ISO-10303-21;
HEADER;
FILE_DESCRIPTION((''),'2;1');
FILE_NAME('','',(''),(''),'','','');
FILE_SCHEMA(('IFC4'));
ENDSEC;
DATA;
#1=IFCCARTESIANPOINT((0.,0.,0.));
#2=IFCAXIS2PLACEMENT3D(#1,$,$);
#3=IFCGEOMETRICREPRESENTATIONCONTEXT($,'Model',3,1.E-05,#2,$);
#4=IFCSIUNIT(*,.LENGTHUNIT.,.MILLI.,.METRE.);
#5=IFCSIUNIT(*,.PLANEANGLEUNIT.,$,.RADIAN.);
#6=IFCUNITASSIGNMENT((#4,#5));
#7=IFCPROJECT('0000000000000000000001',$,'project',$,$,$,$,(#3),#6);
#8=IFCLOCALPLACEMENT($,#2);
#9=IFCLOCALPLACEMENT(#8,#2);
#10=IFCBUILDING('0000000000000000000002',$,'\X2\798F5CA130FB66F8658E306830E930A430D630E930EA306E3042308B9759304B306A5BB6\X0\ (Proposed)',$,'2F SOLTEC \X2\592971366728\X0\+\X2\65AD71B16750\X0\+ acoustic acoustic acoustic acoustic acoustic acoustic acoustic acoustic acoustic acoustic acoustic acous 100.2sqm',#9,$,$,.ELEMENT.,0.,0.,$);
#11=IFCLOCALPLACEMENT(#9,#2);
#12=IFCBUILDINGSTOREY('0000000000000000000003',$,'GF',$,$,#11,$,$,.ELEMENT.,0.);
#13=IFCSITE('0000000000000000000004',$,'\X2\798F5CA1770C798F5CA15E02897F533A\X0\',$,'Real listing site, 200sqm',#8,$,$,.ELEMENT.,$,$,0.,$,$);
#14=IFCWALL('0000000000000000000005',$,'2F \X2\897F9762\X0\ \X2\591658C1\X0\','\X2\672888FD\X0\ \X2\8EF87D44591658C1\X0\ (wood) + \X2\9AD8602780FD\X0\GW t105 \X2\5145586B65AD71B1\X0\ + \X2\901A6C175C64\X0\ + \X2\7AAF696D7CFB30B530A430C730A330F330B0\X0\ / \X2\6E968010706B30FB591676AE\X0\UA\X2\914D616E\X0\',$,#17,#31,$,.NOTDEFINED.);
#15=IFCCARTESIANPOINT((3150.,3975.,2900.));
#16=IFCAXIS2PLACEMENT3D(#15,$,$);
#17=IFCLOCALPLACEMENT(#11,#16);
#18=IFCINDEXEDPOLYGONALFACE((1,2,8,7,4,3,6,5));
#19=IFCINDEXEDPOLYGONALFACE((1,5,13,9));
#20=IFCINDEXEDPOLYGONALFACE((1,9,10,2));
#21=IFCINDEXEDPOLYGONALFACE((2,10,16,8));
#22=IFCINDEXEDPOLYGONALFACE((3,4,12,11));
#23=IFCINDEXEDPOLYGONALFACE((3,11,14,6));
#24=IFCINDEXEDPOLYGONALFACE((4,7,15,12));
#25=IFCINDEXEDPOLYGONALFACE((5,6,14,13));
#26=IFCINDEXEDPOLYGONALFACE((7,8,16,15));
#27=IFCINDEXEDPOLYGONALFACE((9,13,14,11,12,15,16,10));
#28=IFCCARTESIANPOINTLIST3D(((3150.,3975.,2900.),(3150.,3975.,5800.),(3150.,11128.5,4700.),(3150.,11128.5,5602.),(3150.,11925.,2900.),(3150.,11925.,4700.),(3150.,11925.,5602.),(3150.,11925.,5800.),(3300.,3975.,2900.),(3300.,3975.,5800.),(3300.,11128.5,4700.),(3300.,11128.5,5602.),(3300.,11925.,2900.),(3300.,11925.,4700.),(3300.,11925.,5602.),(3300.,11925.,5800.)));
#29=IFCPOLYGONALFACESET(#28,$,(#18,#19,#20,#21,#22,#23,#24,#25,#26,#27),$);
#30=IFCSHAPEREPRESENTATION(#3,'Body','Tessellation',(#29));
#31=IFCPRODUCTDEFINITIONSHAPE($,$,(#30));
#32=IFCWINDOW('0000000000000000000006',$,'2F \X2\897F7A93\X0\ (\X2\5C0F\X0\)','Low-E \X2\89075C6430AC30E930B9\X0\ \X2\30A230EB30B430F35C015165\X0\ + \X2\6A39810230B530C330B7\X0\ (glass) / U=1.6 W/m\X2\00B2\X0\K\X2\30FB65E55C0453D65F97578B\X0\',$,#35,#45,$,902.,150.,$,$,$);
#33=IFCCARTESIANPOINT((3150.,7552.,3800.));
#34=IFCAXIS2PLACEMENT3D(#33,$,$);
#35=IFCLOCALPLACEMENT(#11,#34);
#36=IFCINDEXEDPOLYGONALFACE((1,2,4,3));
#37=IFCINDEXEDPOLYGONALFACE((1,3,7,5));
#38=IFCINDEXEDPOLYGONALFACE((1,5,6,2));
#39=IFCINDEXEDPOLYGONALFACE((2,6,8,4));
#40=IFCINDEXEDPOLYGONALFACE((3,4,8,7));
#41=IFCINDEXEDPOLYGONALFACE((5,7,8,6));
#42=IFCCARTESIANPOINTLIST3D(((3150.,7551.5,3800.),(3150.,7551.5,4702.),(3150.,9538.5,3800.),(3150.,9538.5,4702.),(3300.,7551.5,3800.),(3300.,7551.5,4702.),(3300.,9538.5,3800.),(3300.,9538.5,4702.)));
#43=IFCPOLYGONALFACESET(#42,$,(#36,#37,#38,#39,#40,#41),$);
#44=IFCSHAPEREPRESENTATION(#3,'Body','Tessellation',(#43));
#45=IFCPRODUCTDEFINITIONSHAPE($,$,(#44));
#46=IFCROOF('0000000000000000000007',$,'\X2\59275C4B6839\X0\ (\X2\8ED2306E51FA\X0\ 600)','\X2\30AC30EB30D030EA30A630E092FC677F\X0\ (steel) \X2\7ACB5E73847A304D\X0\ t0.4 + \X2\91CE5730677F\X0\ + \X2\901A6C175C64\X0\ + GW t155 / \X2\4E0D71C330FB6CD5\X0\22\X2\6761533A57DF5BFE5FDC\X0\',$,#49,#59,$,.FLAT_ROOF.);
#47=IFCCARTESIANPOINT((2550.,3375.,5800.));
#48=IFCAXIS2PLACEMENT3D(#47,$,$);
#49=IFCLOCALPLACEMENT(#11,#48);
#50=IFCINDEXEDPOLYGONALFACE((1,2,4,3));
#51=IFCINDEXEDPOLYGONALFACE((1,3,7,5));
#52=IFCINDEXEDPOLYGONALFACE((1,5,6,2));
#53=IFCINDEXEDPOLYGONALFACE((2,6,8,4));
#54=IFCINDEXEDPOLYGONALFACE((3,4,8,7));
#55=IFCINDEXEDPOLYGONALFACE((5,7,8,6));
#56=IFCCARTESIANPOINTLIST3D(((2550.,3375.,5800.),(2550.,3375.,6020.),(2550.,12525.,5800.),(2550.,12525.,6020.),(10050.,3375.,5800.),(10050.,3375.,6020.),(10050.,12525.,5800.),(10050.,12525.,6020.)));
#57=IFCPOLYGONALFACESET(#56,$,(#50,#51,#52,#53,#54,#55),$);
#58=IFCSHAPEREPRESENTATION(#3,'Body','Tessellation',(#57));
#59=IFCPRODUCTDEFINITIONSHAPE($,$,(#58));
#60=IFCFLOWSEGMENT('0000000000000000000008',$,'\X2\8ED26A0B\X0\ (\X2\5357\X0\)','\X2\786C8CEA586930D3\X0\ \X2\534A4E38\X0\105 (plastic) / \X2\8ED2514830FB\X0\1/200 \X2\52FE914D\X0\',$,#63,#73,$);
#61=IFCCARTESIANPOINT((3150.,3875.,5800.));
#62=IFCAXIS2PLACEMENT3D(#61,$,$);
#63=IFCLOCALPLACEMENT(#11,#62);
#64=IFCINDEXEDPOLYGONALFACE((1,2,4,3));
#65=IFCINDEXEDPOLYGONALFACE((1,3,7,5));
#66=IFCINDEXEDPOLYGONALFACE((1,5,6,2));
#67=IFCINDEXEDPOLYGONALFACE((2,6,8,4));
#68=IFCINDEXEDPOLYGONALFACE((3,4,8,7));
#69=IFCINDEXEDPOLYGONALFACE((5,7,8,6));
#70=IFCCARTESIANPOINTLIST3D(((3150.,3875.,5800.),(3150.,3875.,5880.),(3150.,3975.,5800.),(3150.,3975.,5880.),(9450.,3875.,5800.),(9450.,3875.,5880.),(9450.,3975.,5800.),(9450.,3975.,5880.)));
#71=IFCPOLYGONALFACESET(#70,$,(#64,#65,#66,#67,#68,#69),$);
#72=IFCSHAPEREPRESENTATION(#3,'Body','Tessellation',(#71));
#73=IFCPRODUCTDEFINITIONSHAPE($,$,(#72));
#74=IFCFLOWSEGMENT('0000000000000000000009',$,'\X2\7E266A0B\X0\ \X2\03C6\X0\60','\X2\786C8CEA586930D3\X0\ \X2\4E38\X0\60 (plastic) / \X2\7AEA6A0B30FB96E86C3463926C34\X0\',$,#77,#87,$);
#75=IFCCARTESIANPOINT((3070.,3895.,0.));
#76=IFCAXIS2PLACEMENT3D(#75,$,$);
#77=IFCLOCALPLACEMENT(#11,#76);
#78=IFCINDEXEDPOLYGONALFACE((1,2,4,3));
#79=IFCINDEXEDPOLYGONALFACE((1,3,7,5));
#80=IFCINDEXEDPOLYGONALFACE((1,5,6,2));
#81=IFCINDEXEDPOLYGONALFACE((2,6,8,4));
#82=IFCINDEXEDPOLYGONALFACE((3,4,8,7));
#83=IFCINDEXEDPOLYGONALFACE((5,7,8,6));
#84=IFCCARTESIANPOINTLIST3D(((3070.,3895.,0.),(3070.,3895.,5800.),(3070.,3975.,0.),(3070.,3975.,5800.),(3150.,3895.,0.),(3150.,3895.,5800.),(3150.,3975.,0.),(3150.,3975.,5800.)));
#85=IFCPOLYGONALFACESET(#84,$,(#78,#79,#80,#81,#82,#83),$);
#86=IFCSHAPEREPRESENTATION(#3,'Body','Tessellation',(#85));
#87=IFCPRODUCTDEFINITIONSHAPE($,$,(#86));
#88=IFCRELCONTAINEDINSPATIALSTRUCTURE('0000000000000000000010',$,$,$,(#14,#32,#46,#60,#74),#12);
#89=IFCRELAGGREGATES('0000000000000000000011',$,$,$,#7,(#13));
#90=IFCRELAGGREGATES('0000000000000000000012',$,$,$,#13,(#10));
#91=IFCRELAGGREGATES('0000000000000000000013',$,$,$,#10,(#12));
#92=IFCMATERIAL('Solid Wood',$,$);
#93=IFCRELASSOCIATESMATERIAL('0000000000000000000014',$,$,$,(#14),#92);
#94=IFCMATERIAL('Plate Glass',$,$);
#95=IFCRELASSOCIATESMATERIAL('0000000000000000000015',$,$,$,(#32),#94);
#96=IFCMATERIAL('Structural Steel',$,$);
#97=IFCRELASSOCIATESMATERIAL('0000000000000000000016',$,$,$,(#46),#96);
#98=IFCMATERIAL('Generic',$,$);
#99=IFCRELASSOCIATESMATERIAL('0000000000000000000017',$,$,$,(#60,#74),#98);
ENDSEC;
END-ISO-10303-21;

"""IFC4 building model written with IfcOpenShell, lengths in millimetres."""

from ifc_helpers import new_model, si_unit, frame, frame_2d, origin, place, context, project, spatial, rectangle, extrude, material, element, fill, save


model = new_model("IFC4")

# Units and contexts
model_context = context("Model", 3, precision=1e-05, world=origin())
ifc_project = project(units=[si_unit("LENGTHUNIT", "METRE", prefix="MILLI"), si_unit("PLANEANGLEUNIT", "RADIAN")], contexts=[model_context])

# Site, building, storey
site_placement = place(None, origin())
site = spatial("IfcSite", under=ifc_project, at=site_placement, Name="福岡県福岡市西区", ObjectType="Real listing site, 200sqm", CompositionType="ELEMENT", RefElevation=0.0)
building_placement = place(site_placement, origin())
building = spatial("IfcBuilding", under=site, at=building_placement, Name="福岡・書斎とライブラリのある静かな家 (Proposed)", ObjectType="2F SOLTEC 天然木+断熱材+ acoustic acoustic acoustic acoustic acoustic acoustic acoustic acoustic acoustic acoustic acoustic acous 100.2sqm", CompositionType="ELEMENT", ElevationOfRefHeight=0.0, ElevationOfTerrain=0.0)
storey_placement = place(building_placement, origin())
storey = spatial("IfcBuildingStorey", under=building, at=storey_placement, Name="GF", CompositionType="ELEMENT", Elevation=0.0)

# Shared definitions
ifc_material_1 = material(Name="Solid Wood")

# Shared definitions
ifc_material_2 = material(Name="Plate Glass")

# Wall, opening, window
wall_1_placement = place(storey_placement, frame((3150.0, 3975.0, 2900.0)))
wall_1 = element("IfcWall", 1, at=wall_1_placement, inside=storey, material=ifc_material_1, Name="2F 西面 外壁", Description="木製 軸組外壁 (wood) + 高性能GW t105 充填断熱 + 通気層 + 窯業系サイディング / 準耐火・外皮UA配慮", PredefinedType="NOTDEFINED", context=model_context, shape_type="SweptSolid", body=[
    extrude(rectangle(XDim=150.0, YDim=7950.0, at=frame_2d((75.0, 3975.0))), frame((3150.0, 3975.0, 2900.0)), (0.0, 0.0, 1.0), 2900.0),
])
opening_1_placement = place(storey_placement, frame((3150.0, 7552.0, 3800.0)))
opening_1 = element("IfcOpeningElement", 2, at=opening_1_placement, cuts=wall_1, PredefinedType="NOTDEFINED", context=model_context, shape_type="SweptSolid", body=[
    extrude(rectangle(XDim=150.0, YDim=1987.0, at=frame_2d((75.0, 993.0))), frame((3150.0, 7552.0, 3800.0)), (0.0, 0.0, 1.0), 902.0),
])
window_1_placement = place(storey_placement, frame((3150.0, 7552.0, 3800.0)))
window_1 = element("IfcWindow", 3, at=window_1_placement, inside=storey, material=ifc_material_2, Name="2F 西窓 (小)", Description="Low-E 複層ガラス アルゴン封入 + 樹脂サッシ (glass) / U=1.6 W/m²K・日射取得型", OverallHeight=902.0, OverallWidth=150.0, context=model_context, shape_type="SweptSolid", body=[
    extrude(rectangle(XDim=150.0, YDim=1987.0, at=frame_2d((75.0, 993.0))), frame((3150.0, 7552.0, 3800.0)), (0.0, 0.0, 1.0), 902.0),
])
fill(opening_1, window_1)

# Roof
ifc_material_3 = material(Name="Structural Steel")
roof_placement = place(storey_placement, frame((2550.0, 3375.0, 5800.0)))
element("IfcRoof", 4, at=roof_placement, inside=storey, material=ifc_material_3, Name="大屋根 (軒の出 600)", Description="ガルバリウム鋼板 (steel) 立平葺き t0.4 + 野地板 + 通気層 + GW t155 / 不燃・法22条区域対応", PredefinedType="FLAT_ROOF", context=model_context, shape_type="SweptSolid", body=[
    extrude(rectangle(XDim=7500.0, YDim=9150.0, at=frame_2d((3750.0, 4575.0))), frame((2550.0, 3375.0, 5800.0)), (0.0, 0.0, 1.0), 220.0),
])

# Flow segments
ifc_material_4 = material(Name="Generic")
flow_segment_1_placement = place(storey_placement, frame((3150.0, 3875.0, 5800.0)))
element("IfcFlowSegment", 5, at=flow_segment_1_placement, inside=storey, material=ifc_material_4, Name="軒樋 (南)", Description="硬質塩ビ 半丸105 (plastic) / 軒先・1/200 勾配", context=model_context, shape_type="SweptSolid", body=[
    extrude(rectangle(XDim=6300.0, YDim=100.0, at=frame_2d((3150.0, 50.0))), frame((3150.0, 3875.0, 5800.0)), (0.0, 0.0, 1.0), 80.0),
])
flow_segment_2_placement = place(storey_placement, frame((3070.0, 3895.0, 0.0)))
element("IfcFlowSegment", 6, at=flow_segment_2_placement, inside=storey, material=ifc_material_4, Name="縦樋 φ60", Description="硬質塩ビ 丸60 (plastic) / 竪樋・雨水排水", context=model_context, shape_type="SweptSolid", body=[
    extrude(rectangle(XDim=80.0, YDim=80.0, at=frame_2d((40.0, 40.0))), frame((3070.0, 3895.0, 0.0)), (0.0, 0.0, 1.0), 5800.0),
])

save(model, "model.ifc")
